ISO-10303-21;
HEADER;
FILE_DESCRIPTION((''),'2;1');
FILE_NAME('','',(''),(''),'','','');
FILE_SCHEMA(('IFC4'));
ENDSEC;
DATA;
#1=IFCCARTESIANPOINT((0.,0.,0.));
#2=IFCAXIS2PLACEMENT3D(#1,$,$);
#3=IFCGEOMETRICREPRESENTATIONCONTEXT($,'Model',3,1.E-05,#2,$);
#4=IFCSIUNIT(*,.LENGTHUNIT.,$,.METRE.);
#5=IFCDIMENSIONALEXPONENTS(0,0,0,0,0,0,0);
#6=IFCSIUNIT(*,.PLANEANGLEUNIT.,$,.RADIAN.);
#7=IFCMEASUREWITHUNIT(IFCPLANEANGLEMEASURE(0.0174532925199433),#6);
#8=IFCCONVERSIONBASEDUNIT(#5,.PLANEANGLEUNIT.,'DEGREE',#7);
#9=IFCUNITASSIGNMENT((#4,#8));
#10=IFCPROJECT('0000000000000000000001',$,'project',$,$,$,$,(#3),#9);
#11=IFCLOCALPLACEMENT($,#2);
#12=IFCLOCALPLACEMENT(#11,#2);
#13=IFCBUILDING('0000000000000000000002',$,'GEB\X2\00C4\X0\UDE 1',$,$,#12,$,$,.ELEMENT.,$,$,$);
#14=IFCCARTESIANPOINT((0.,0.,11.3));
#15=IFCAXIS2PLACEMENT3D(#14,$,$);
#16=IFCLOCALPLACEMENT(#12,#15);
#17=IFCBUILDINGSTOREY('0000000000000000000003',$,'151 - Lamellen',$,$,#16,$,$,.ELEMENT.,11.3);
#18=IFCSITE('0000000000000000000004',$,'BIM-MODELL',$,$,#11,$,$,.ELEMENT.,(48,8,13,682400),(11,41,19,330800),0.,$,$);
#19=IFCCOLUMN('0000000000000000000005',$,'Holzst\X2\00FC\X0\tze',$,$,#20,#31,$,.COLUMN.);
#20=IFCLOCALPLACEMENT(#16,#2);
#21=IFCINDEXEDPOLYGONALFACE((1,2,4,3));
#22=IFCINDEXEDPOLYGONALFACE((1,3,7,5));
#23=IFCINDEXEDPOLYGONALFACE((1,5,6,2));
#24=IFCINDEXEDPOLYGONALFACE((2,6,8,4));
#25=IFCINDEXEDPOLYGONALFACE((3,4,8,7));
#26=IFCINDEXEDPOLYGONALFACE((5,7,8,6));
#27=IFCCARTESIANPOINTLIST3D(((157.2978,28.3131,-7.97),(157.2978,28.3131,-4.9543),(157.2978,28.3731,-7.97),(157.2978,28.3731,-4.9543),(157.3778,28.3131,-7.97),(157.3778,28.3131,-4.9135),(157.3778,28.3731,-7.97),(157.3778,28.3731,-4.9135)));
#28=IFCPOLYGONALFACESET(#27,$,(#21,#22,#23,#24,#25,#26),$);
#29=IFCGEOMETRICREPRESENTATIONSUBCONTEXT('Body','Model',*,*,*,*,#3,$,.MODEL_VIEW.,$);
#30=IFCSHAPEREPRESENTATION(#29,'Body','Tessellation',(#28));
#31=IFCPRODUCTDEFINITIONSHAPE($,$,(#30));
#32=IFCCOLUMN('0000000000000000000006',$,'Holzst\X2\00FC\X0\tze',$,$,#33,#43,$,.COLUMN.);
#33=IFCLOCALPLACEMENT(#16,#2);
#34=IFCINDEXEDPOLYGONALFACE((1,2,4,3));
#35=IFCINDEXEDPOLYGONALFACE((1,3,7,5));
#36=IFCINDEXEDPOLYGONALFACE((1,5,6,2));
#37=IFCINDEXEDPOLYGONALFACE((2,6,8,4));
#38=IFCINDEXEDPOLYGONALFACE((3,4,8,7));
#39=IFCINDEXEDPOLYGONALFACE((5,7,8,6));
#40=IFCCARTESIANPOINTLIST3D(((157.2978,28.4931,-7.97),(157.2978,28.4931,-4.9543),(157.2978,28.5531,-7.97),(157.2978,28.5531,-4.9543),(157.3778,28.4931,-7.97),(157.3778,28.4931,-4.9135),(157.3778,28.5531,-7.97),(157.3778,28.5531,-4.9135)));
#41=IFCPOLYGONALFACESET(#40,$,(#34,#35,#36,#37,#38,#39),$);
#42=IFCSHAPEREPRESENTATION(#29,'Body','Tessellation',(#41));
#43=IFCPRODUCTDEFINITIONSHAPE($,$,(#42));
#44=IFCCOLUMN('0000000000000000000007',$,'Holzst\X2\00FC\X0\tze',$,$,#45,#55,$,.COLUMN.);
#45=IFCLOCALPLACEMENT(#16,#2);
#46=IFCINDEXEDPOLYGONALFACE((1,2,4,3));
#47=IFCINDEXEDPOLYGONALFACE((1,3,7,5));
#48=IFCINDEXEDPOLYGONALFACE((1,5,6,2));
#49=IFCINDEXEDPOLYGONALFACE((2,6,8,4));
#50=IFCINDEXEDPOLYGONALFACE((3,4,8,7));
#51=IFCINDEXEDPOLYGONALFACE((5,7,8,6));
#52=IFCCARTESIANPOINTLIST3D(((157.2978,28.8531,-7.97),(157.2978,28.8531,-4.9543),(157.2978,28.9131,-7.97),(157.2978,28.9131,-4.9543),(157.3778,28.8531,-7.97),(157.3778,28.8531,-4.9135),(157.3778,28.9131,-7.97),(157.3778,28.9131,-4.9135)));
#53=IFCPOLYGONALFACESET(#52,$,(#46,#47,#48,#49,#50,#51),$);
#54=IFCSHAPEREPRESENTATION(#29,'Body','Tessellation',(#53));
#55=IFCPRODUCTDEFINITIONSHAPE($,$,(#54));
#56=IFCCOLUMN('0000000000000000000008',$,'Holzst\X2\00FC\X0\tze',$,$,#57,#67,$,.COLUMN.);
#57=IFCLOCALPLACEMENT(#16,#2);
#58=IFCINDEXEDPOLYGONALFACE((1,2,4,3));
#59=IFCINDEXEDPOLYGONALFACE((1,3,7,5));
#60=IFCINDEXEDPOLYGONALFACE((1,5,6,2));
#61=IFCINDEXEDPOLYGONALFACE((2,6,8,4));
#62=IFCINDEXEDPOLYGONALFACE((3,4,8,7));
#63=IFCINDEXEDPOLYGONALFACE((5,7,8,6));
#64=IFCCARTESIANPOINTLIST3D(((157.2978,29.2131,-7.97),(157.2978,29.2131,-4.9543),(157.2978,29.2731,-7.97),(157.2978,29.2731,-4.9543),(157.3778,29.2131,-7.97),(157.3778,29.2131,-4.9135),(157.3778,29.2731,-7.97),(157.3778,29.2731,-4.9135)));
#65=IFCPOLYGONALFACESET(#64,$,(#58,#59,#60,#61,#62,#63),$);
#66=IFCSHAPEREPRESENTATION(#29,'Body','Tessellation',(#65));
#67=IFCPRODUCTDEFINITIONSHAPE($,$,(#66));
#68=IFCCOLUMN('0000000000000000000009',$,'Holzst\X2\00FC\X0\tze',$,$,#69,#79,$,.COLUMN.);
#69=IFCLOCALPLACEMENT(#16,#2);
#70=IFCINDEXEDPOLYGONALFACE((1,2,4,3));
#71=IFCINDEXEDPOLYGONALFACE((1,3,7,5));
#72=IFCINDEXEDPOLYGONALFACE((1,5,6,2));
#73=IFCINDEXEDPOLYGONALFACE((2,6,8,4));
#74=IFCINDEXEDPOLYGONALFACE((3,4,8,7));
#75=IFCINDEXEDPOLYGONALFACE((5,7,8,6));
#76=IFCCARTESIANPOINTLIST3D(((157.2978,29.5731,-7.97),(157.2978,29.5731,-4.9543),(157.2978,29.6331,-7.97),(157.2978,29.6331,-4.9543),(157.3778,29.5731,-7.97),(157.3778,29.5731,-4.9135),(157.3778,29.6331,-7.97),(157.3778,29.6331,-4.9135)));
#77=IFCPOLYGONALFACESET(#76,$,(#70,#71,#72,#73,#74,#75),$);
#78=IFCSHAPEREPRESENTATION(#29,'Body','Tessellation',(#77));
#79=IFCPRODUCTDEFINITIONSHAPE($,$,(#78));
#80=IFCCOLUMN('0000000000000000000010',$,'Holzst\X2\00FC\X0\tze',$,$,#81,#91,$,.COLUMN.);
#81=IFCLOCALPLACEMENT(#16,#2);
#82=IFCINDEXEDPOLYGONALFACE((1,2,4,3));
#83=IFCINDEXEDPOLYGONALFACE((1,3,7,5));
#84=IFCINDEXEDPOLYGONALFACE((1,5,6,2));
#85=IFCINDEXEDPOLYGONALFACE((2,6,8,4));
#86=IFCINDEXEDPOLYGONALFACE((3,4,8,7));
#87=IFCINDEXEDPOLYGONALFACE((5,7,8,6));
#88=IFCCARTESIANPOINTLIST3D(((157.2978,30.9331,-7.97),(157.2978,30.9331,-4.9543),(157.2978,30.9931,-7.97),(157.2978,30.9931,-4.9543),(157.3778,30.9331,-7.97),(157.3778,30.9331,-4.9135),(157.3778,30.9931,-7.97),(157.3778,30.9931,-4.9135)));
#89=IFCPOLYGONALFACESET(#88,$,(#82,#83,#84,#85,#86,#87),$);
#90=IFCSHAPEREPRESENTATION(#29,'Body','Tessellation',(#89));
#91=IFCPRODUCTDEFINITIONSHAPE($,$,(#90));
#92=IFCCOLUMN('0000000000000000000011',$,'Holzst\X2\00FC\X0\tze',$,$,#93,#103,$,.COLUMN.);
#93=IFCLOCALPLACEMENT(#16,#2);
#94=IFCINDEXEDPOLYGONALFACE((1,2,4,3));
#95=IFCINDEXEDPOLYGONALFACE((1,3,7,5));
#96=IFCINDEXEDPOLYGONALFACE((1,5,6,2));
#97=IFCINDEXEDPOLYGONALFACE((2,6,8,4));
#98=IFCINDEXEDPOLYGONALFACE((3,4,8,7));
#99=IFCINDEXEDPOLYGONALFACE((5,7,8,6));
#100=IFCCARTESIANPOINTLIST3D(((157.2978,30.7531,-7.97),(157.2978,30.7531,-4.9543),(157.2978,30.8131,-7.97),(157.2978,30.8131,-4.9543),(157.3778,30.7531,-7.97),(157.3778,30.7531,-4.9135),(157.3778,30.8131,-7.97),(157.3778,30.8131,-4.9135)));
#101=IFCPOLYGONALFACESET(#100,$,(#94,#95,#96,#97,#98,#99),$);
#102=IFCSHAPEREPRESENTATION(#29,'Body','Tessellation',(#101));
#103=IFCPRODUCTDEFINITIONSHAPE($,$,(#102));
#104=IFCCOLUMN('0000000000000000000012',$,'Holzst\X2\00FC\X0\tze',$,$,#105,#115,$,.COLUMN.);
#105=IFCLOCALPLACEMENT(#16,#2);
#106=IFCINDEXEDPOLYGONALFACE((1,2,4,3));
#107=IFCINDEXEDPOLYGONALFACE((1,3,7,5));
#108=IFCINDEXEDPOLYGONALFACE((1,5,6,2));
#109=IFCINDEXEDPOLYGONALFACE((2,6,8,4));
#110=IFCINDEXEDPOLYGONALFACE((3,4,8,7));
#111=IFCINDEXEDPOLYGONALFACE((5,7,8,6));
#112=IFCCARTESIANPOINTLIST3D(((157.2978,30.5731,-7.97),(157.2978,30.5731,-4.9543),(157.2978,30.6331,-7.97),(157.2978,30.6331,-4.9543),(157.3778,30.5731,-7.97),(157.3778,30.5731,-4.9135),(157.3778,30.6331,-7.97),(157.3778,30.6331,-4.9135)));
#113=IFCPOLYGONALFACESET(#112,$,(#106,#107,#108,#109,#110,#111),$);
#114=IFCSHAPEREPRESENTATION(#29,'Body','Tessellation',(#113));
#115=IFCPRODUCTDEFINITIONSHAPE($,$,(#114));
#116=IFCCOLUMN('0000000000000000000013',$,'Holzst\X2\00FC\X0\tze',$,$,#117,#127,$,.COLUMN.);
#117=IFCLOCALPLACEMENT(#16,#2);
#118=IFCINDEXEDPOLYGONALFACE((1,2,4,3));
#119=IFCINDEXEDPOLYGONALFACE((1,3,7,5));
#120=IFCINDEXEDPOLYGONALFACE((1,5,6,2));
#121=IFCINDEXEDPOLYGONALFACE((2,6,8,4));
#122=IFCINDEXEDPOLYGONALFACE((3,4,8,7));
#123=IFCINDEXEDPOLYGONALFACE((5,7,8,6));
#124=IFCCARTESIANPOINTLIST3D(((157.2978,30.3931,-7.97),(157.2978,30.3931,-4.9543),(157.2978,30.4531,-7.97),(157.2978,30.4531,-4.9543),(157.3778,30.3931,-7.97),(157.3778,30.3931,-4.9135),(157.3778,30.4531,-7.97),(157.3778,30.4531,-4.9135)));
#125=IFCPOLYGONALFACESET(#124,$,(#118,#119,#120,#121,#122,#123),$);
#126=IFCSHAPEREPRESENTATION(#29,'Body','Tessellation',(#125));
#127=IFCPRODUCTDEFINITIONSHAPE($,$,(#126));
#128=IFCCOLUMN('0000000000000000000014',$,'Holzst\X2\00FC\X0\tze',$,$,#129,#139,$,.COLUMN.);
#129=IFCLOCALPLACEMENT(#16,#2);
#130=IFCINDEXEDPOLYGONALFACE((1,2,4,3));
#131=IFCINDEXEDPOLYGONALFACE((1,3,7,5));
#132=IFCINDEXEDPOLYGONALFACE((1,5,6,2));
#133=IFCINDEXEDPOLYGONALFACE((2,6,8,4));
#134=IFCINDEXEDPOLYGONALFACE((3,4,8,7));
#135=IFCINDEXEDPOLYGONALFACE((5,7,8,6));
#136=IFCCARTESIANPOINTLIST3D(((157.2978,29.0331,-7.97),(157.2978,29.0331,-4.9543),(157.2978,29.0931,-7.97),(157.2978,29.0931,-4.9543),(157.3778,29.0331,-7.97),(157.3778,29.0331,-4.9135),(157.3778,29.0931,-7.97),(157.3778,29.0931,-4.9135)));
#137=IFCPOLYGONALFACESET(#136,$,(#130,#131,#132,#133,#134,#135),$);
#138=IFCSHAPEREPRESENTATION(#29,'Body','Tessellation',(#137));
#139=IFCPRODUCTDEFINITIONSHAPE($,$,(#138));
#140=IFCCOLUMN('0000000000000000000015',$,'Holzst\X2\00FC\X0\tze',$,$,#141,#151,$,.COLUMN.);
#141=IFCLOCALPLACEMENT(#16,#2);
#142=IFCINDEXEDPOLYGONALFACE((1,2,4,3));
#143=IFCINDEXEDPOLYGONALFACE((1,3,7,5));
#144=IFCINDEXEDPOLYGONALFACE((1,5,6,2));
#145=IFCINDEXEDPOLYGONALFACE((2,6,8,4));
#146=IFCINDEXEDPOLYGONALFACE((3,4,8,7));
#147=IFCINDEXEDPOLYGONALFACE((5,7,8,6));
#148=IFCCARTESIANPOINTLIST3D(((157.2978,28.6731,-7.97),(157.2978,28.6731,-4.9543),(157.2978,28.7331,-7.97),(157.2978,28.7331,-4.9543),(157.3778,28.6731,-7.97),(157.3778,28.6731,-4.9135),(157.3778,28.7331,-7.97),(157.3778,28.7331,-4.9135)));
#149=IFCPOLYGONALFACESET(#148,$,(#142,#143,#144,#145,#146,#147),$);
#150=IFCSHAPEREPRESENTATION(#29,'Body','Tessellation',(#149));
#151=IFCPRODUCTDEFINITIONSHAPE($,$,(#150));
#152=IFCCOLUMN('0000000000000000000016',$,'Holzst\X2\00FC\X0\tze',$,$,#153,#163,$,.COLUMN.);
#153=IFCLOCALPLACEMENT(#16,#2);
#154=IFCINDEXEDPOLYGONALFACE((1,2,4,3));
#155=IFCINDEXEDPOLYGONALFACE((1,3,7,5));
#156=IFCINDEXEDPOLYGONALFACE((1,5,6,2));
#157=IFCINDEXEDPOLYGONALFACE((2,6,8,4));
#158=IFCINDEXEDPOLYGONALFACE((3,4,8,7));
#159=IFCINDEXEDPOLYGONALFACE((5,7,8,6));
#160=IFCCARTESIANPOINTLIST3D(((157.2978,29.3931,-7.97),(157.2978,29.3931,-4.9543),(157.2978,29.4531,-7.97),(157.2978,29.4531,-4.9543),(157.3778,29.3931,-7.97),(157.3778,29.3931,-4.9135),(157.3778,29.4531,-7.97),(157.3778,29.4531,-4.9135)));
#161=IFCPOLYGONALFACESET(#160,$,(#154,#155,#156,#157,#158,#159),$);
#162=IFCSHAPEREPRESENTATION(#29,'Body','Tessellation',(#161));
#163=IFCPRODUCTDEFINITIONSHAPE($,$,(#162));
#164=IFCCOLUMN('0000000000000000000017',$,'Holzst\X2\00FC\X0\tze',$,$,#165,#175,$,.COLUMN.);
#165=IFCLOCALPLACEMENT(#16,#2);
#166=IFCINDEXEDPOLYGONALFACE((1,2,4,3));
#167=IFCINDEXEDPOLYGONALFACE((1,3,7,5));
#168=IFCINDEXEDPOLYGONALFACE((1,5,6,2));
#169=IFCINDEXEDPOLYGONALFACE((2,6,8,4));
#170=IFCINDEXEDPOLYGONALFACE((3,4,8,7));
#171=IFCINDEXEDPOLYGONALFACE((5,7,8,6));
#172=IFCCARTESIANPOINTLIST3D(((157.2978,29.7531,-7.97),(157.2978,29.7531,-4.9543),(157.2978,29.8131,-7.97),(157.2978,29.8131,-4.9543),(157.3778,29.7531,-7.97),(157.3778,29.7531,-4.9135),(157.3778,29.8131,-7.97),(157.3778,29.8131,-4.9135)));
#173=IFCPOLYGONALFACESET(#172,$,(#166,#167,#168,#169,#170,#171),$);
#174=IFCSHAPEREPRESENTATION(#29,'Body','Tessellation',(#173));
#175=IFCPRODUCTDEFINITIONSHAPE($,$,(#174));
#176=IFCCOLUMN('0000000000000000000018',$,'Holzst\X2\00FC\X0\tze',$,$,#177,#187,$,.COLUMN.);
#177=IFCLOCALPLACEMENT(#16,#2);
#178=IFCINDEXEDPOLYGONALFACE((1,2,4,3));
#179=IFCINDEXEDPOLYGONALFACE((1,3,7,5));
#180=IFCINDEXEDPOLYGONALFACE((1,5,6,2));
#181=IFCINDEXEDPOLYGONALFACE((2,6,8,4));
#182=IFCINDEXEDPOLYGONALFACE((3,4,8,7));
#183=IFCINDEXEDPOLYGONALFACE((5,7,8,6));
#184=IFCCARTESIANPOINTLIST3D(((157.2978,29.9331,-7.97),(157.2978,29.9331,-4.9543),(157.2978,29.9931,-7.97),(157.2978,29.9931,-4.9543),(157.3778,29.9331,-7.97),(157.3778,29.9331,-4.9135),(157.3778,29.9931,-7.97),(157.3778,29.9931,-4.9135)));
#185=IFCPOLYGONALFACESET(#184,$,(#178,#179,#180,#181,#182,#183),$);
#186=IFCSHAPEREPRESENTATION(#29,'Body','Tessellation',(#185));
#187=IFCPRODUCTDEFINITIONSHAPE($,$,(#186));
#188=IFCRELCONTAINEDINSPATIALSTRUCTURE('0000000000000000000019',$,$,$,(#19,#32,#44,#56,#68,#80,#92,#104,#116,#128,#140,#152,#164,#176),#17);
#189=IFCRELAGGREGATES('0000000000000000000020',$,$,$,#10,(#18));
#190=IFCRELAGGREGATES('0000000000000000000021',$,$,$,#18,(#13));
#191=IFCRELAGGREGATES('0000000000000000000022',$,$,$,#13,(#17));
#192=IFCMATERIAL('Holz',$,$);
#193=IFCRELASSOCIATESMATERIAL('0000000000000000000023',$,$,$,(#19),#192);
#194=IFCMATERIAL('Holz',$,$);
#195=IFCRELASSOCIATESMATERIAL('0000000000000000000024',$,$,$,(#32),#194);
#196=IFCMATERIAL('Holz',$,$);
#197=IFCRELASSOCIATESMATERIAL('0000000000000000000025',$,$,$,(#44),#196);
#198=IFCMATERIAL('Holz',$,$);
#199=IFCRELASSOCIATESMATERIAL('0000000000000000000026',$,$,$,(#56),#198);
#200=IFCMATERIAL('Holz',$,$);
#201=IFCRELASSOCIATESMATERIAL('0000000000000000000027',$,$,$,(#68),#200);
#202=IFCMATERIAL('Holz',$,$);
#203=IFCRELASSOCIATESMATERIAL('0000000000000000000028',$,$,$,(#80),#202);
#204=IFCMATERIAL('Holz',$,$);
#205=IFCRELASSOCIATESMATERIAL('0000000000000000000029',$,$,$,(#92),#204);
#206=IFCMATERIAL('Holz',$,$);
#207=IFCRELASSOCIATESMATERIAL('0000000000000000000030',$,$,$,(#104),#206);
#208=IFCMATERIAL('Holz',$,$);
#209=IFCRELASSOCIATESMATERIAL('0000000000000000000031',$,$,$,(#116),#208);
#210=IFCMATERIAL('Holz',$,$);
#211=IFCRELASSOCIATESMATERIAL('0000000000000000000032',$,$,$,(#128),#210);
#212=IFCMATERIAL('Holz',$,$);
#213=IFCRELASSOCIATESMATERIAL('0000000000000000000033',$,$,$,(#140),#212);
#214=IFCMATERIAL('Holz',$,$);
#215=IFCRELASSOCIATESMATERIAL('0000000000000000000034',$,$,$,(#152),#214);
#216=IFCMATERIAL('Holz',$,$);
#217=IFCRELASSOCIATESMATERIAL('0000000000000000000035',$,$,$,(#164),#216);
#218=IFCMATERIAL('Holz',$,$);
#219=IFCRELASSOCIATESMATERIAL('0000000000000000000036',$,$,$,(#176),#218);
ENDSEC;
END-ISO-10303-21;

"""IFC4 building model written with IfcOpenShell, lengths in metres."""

from ifc_helpers import new_model, entity, si_unit, converted_unit, frame, frame_2d, origin, origin_with_axes, place, context, subcontext, project, spatial, rectangle, extrude, clip, halfspace, material, element, save


model = new_model("IFC4")

# Units and contexts
model_context = context("Model", 3, precision=1e-05, world=origin())
body_context = subcontext(model_context, "Body", "Model", "MODEL_VIEW")
ifc_project = project(units=[si_unit("LENGTHUNIT", "METRE"), converted_unit("PLANEANGLEUNIT", "DEGREE", entity("IfcPlaneAngleMeasure", 0.0174532925199433), si_unit("PLANEANGLEUNIT", "RADIAN"), dimensions=[0, 0, 0, 0, 0, 0, 0])], contexts=[model_context])

# Site, building, storey
site_placement = place(None, origin())
site = spatial("IfcSite", under=ifc_project, at=site_placement, Name="BIM-MODELL", CompositionType="ELEMENT", RefLatitude=(48, 8, 13, 682400), RefLongitude=(11, 41, 19, 330800), RefElevation=0.0)
building_placement = place(site_placement, origin())
building = spatial("IfcBuilding", under=site, at=building_placement, Name="GEBÄUDE 1", CompositionType="ELEMENT")
storey_placement = place(building_placement, frame((0.0, 0.0, 11.3)))
storey = spatial("IfcBuildingStorey", under=building, at=storey_placement, Name="151 - Lamellen", CompositionType="ELEMENT", Elevation=11.3)

# Columns
ifc_material_1 = material(Name="Holz")
column_1_placement = place(storey_placement, frame((157.3778, 28.3131, -7.97)))
element("IfcColumn", 1, at=column_1_placement, inside=storey, material=ifc_material_1, Name="Holzstütze", PredefinedType="COLUMN", context=body_context, shape_type="Clipping", body=[
    clip(extrude(rectangle(XDim=0.06, YDim=0.08, at=frame_2d((-0.04, 0.03), x_axis=(0.0, 1.0))), origin_with_axes(), (0.0, 0.0, 1.0), 3.0565), halfspace(frame((-0.04, 0.03, 3.0361), z_axis=(0.45399, 0.0, -0.891007), x_axis=(-0.891007, 0.0, -0.45399)), True)),
])
ifc_material_2 = material(Name="Holz")
column_2_placement = place(storey_placement, frame((157.3778, 28.4931, -7.97)))
element("IfcColumn", 2, at=column_2_placement, inside=storey, material=ifc_material_2, Name="Holzstütze", PredefinedType="COLUMN", context=body_context, shape_type="Clipping", body=[
    clip(extrude(rectangle(XDim=0.06, YDim=0.08, at=frame_2d((-0.04, 0.03), x_axis=(0.0, 1.0))), origin_with_axes(), (0.0, 0.0, 1.0), 3.0565), halfspace(frame((-0.04, 0.03, 3.0361), z_axis=(0.45399, 0.0, -0.891007), x_axis=(-0.891007, 0.0, -0.45399)), True)),
])
ifc_material_3 = material(Name="Holz")
column_3_placement = place(storey_placement, frame((157.3778, 28.8531, -7.97)))
element("IfcColumn", 3, at=column_3_placement, inside=storey, material=ifc_material_3, Name="Holzstütze", PredefinedType="COLUMN", context=body_context, shape_type="Clipping", body=[
    clip(extrude(rectangle(XDim=0.06, YDim=0.08, at=frame_2d((-0.04, 0.03), x_axis=(0.0, 1.0))), origin_with_axes(), (0.0, 0.0, 1.0), 3.0565), halfspace(frame((-0.04, 0.03, 3.0361), z_axis=(0.45399, 0.0, -0.891007), x_axis=(-0.891007, 0.0, -0.45399)), True)),
])
ifc_material_4 = material(Name="Holz")
column_4_placement = place(storey_placement, frame((157.3778, 29.2131, -7.97)))
element("IfcColumn", 4, at=column_4_placement, inside=storey, material=ifc_material_4, Name="Holzstütze", PredefinedType="COLUMN", context=body_context, shape_type="Clipping", body=[
    clip(extrude(rectangle(XDim=0.06, YDim=0.08, at=frame_2d((-0.04, 0.03), x_axis=(0.0, 1.0))), origin_with_axes(), (0.0, 0.0, 1.0), 3.0565), halfspace(frame((-0.04, 0.03, 3.0361), z_axis=(0.45399, 0.0, -0.891007), x_axis=(-0.891007, 0.0, -0.45399)), True)),
])
ifc_material_5 = material(Name="Holz")
column_5_placement = place(storey_placement, frame((157.3778, 29.5731, -7.97)))
element("IfcColumn", 5, at=column_5_placement, inside=storey, material=ifc_material_5, Name="Holzstütze", PredefinedType="COLUMN", context=body_context, shape_type="Clipping", body=[
    clip(extrude(rectangle(XDim=0.06, YDim=0.08, at=frame_2d((-0.04, 0.03), x_axis=(0.0, 1.0))), origin_with_axes(), (0.0, 0.0, 1.0), 3.0565), halfspace(frame((-0.04, 0.03, 3.0361), z_axis=(0.45399, 0.0, -0.891007), x_axis=(-0.891007, 0.0, -0.45399)), True)),
])
ifc_material_6 = material(Name="Holz")
column_6_placement = place(storey_placement, frame((157.3778, 30.9331, -7.97)))
element("IfcColumn", 6, at=column_6_placement, inside=storey, material=ifc_material_6, Name="Holzstütze", PredefinedType="COLUMN", context=body_context, shape_type="Clipping", body=[
    clip(extrude(rectangle(XDim=0.06, YDim=0.08, at=frame_2d((-0.04, 0.03), x_axis=(0.0, 1.0))), origin_with_axes(), (0.0, 0.0, 1.0), 3.0565), halfspace(frame((-0.04, 0.03, 3.0361), z_axis=(0.45399, 0.0, -0.891007), x_axis=(-0.891007, 0.0, -0.45399)), True)),
])
ifc_material_7 = material(Name="Holz")
column_7_placement = place(storey_placement, frame((157.3778, 30.7531, -7.97)))
element("IfcColumn", 7, at=column_7_placement, inside=storey, material=ifc_material_7, Name="Holzstütze", PredefinedType="COLUMN", context=body_context, shape_type="Clipping", body=[
    clip(extrude(rectangle(XDim=0.06, YDim=0.08, at=frame_2d((-0.04, 0.03), x_axis=(0.0, 1.0))), origin_with_axes(), (0.0, 0.0, 1.0), 3.0565), halfspace(frame((-0.04, 0.03, 3.0361), z_axis=(0.45399, 0.0, -0.891007), x_axis=(-0.891007, 0.0, -0.45399)), True)),
])
ifc_material_8 = material(Name="Holz")
column_8_placement = place(storey_placement, frame((157.3778, 30.5731, -7.97)))
element("IfcColumn", 8, at=column_8_placement, inside=storey, material=ifc_material_8, Name="Holzstütze", PredefinedType="COLUMN", context=body_context, shape_type="Clipping", body=[
    clip(extrude(rectangle(XDim=0.06, YDim=0.08, at=frame_2d((-0.04, 0.03), x_axis=(0.0, 1.0))), origin_with_axes(), (0.0, 0.0, 1.0), 3.0565), halfspace(frame((-0.04, 0.03, 3.0361), z_axis=(0.45399, 0.0, -0.891007), x_axis=(-0.891007, 0.0, -0.45399)), True)),
])
ifc_material_9 = material(Name="Holz")
column_9_placement = place(storey_placement, frame((157.3778, 30.3931, -7.97)))
element("IfcColumn", 9, at=column_9_placement, inside=storey, material=ifc_material_9, Name="Holzstütze", PredefinedType="COLUMN", context=body_context, shape_type="Clipping", body=[
    clip(extrude(rectangle(XDim=0.06, YDim=0.08, at=frame_2d((-0.04, 0.03), x_axis=(0.0, 1.0))), origin_with_axes(), (0.0, 0.0, 1.0), 3.0565), halfspace(frame((-0.04, 0.03, 3.0361), z_axis=(0.45399, 0.0, -0.891007), x_axis=(-0.891007, 0.0, -0.45399)), True)),
])
ifc_material_10 = material(Name="Holz")
column_10_placement = place(storey_placement, frame((157.3778, 29.0331, -7.97)))
element("IfcColumn", 10, at=column_10_placement, inside=storey, material=ifc_material_10, Name="Holzstütze", PredefinedType="COLUMN", context=body_context, shape_type="Clipping", body=[
    clip(extrude(rectangle(XDim=0.06, YDim=0.08, at=frame_2d((-0.04, 0.03), x_axis=(0.0, 1.0))), origin_with_axes(), (0.0, 0.0, 1.0), 3.0565), halfspace(frame((-0.04, 0.03, 3.0361), z_axis=(0.45399, 0.0, -0.891007), x_axis=(-0.891007, 0.0, -0.45399)), True)),
])
ifc_material_11 = material(Name="Holz")
column_11_placement = place(storey_placement, frame((157.3778, 28.6731, -7.97)))
element("IfcColumn", 11, at=column_11_placement, inside=storey, material=ifc_material_11, Name="Holzstütze", PredefinedType="COLUMN", context=body_context, shape_type="Clipping", body=[
    clip(extrude(rectangle(XDim=0.06, YDim=0.08, at=frame_2d((-0.04, 0.03), x_axis=(0.0, 1.0))), origin_with_axes(), (0.0, 0.0, 1.0), 3.0565), halfspace(frame((-0.04, 0.03, 3.0361), z_axis=(0.45399, 0.0, -0.891007), x_axis=(-0.891007, 0.0, -0.45399)), True)),
])
ifc_material_12 = material(Name="Holz")
column_12_placement = place(storey_placement, frame((157.3778, 29.3931, -7.97)))
element("IfcColumn", 12, at=column_12_placement, inside=storey, material=ifc_material_12, Name="Holzstütze", PredefinedType="COLUMN", context=body_context, shape_type="Clipping", body=[
    clip(extrude(rectangle(XDim=0.06, YDim=0.08, at=frame_2d((-0.04, 0.03), x_axis=(0.0, 1.0))), origin_with_axes(), (0.0, 0.0, 1.0), 3.0565), halfspace(frame((-0.04, 0.03, 3.0361), z_axis=(0.45399, 0.0, -0.891007), x_axis=(-0.891007, 0.0, -0.45399)), True)),
])
ifc_material_13 = material(Name="Holz")
column_13_placement = place(storey_placement, frame((157.3778, 29.7531, -7.97)))
element("IfcColumn", 13, at=column_13_placement, inside=storey, material=ifc_material_13, Name="Holzstütze", PredefinedType="COLUMN", context=body_context, shape_type="Clipping", body=[
    clip(extrude(rectangle(XDim=0.06, YDim=0.08, at=frame_2d((-0.04, 0.03), x_axis=(0.0, 1.0))), origin_with_axes(), (0.0, 0.0, 1.0), 3.0565), halfspace(frame((-0.04, 0.03, 3.0361), z_axis=(0.45399, 0.0, -0.891007), x_axis=(-0.891007, 0.0, -0.45399)), True)),
])
ifc_material_14 = material(Name="Holz")
column_14_placement = place(storey_placement, frame((157.3778, 29.9331, -7.97)))
element("IfcColumn", 14, at=column_14_placement, inside=storey, material=ifc_material_14, Name="Holzstütze", PredefinedType="COLUMN", context=body_context, shape_type="Clipping", body=[
    clip(extrude(rectangle(XDim=0.06, YDim=0.08, at=frame_2d((-0.04, 0.03), x_axis=(0.0, 1.0))), origin_with_axes(), (0.0, 0.0, 1.0), 3.0565), halfspace(frame((-0.04, 0.03, 3.0361), z_axis=(0.45399, 0.0, -0.891007), x_axis=(-0.891007, 0.0, -0.45399)), True)),
])

save(model, "model.ifc")
